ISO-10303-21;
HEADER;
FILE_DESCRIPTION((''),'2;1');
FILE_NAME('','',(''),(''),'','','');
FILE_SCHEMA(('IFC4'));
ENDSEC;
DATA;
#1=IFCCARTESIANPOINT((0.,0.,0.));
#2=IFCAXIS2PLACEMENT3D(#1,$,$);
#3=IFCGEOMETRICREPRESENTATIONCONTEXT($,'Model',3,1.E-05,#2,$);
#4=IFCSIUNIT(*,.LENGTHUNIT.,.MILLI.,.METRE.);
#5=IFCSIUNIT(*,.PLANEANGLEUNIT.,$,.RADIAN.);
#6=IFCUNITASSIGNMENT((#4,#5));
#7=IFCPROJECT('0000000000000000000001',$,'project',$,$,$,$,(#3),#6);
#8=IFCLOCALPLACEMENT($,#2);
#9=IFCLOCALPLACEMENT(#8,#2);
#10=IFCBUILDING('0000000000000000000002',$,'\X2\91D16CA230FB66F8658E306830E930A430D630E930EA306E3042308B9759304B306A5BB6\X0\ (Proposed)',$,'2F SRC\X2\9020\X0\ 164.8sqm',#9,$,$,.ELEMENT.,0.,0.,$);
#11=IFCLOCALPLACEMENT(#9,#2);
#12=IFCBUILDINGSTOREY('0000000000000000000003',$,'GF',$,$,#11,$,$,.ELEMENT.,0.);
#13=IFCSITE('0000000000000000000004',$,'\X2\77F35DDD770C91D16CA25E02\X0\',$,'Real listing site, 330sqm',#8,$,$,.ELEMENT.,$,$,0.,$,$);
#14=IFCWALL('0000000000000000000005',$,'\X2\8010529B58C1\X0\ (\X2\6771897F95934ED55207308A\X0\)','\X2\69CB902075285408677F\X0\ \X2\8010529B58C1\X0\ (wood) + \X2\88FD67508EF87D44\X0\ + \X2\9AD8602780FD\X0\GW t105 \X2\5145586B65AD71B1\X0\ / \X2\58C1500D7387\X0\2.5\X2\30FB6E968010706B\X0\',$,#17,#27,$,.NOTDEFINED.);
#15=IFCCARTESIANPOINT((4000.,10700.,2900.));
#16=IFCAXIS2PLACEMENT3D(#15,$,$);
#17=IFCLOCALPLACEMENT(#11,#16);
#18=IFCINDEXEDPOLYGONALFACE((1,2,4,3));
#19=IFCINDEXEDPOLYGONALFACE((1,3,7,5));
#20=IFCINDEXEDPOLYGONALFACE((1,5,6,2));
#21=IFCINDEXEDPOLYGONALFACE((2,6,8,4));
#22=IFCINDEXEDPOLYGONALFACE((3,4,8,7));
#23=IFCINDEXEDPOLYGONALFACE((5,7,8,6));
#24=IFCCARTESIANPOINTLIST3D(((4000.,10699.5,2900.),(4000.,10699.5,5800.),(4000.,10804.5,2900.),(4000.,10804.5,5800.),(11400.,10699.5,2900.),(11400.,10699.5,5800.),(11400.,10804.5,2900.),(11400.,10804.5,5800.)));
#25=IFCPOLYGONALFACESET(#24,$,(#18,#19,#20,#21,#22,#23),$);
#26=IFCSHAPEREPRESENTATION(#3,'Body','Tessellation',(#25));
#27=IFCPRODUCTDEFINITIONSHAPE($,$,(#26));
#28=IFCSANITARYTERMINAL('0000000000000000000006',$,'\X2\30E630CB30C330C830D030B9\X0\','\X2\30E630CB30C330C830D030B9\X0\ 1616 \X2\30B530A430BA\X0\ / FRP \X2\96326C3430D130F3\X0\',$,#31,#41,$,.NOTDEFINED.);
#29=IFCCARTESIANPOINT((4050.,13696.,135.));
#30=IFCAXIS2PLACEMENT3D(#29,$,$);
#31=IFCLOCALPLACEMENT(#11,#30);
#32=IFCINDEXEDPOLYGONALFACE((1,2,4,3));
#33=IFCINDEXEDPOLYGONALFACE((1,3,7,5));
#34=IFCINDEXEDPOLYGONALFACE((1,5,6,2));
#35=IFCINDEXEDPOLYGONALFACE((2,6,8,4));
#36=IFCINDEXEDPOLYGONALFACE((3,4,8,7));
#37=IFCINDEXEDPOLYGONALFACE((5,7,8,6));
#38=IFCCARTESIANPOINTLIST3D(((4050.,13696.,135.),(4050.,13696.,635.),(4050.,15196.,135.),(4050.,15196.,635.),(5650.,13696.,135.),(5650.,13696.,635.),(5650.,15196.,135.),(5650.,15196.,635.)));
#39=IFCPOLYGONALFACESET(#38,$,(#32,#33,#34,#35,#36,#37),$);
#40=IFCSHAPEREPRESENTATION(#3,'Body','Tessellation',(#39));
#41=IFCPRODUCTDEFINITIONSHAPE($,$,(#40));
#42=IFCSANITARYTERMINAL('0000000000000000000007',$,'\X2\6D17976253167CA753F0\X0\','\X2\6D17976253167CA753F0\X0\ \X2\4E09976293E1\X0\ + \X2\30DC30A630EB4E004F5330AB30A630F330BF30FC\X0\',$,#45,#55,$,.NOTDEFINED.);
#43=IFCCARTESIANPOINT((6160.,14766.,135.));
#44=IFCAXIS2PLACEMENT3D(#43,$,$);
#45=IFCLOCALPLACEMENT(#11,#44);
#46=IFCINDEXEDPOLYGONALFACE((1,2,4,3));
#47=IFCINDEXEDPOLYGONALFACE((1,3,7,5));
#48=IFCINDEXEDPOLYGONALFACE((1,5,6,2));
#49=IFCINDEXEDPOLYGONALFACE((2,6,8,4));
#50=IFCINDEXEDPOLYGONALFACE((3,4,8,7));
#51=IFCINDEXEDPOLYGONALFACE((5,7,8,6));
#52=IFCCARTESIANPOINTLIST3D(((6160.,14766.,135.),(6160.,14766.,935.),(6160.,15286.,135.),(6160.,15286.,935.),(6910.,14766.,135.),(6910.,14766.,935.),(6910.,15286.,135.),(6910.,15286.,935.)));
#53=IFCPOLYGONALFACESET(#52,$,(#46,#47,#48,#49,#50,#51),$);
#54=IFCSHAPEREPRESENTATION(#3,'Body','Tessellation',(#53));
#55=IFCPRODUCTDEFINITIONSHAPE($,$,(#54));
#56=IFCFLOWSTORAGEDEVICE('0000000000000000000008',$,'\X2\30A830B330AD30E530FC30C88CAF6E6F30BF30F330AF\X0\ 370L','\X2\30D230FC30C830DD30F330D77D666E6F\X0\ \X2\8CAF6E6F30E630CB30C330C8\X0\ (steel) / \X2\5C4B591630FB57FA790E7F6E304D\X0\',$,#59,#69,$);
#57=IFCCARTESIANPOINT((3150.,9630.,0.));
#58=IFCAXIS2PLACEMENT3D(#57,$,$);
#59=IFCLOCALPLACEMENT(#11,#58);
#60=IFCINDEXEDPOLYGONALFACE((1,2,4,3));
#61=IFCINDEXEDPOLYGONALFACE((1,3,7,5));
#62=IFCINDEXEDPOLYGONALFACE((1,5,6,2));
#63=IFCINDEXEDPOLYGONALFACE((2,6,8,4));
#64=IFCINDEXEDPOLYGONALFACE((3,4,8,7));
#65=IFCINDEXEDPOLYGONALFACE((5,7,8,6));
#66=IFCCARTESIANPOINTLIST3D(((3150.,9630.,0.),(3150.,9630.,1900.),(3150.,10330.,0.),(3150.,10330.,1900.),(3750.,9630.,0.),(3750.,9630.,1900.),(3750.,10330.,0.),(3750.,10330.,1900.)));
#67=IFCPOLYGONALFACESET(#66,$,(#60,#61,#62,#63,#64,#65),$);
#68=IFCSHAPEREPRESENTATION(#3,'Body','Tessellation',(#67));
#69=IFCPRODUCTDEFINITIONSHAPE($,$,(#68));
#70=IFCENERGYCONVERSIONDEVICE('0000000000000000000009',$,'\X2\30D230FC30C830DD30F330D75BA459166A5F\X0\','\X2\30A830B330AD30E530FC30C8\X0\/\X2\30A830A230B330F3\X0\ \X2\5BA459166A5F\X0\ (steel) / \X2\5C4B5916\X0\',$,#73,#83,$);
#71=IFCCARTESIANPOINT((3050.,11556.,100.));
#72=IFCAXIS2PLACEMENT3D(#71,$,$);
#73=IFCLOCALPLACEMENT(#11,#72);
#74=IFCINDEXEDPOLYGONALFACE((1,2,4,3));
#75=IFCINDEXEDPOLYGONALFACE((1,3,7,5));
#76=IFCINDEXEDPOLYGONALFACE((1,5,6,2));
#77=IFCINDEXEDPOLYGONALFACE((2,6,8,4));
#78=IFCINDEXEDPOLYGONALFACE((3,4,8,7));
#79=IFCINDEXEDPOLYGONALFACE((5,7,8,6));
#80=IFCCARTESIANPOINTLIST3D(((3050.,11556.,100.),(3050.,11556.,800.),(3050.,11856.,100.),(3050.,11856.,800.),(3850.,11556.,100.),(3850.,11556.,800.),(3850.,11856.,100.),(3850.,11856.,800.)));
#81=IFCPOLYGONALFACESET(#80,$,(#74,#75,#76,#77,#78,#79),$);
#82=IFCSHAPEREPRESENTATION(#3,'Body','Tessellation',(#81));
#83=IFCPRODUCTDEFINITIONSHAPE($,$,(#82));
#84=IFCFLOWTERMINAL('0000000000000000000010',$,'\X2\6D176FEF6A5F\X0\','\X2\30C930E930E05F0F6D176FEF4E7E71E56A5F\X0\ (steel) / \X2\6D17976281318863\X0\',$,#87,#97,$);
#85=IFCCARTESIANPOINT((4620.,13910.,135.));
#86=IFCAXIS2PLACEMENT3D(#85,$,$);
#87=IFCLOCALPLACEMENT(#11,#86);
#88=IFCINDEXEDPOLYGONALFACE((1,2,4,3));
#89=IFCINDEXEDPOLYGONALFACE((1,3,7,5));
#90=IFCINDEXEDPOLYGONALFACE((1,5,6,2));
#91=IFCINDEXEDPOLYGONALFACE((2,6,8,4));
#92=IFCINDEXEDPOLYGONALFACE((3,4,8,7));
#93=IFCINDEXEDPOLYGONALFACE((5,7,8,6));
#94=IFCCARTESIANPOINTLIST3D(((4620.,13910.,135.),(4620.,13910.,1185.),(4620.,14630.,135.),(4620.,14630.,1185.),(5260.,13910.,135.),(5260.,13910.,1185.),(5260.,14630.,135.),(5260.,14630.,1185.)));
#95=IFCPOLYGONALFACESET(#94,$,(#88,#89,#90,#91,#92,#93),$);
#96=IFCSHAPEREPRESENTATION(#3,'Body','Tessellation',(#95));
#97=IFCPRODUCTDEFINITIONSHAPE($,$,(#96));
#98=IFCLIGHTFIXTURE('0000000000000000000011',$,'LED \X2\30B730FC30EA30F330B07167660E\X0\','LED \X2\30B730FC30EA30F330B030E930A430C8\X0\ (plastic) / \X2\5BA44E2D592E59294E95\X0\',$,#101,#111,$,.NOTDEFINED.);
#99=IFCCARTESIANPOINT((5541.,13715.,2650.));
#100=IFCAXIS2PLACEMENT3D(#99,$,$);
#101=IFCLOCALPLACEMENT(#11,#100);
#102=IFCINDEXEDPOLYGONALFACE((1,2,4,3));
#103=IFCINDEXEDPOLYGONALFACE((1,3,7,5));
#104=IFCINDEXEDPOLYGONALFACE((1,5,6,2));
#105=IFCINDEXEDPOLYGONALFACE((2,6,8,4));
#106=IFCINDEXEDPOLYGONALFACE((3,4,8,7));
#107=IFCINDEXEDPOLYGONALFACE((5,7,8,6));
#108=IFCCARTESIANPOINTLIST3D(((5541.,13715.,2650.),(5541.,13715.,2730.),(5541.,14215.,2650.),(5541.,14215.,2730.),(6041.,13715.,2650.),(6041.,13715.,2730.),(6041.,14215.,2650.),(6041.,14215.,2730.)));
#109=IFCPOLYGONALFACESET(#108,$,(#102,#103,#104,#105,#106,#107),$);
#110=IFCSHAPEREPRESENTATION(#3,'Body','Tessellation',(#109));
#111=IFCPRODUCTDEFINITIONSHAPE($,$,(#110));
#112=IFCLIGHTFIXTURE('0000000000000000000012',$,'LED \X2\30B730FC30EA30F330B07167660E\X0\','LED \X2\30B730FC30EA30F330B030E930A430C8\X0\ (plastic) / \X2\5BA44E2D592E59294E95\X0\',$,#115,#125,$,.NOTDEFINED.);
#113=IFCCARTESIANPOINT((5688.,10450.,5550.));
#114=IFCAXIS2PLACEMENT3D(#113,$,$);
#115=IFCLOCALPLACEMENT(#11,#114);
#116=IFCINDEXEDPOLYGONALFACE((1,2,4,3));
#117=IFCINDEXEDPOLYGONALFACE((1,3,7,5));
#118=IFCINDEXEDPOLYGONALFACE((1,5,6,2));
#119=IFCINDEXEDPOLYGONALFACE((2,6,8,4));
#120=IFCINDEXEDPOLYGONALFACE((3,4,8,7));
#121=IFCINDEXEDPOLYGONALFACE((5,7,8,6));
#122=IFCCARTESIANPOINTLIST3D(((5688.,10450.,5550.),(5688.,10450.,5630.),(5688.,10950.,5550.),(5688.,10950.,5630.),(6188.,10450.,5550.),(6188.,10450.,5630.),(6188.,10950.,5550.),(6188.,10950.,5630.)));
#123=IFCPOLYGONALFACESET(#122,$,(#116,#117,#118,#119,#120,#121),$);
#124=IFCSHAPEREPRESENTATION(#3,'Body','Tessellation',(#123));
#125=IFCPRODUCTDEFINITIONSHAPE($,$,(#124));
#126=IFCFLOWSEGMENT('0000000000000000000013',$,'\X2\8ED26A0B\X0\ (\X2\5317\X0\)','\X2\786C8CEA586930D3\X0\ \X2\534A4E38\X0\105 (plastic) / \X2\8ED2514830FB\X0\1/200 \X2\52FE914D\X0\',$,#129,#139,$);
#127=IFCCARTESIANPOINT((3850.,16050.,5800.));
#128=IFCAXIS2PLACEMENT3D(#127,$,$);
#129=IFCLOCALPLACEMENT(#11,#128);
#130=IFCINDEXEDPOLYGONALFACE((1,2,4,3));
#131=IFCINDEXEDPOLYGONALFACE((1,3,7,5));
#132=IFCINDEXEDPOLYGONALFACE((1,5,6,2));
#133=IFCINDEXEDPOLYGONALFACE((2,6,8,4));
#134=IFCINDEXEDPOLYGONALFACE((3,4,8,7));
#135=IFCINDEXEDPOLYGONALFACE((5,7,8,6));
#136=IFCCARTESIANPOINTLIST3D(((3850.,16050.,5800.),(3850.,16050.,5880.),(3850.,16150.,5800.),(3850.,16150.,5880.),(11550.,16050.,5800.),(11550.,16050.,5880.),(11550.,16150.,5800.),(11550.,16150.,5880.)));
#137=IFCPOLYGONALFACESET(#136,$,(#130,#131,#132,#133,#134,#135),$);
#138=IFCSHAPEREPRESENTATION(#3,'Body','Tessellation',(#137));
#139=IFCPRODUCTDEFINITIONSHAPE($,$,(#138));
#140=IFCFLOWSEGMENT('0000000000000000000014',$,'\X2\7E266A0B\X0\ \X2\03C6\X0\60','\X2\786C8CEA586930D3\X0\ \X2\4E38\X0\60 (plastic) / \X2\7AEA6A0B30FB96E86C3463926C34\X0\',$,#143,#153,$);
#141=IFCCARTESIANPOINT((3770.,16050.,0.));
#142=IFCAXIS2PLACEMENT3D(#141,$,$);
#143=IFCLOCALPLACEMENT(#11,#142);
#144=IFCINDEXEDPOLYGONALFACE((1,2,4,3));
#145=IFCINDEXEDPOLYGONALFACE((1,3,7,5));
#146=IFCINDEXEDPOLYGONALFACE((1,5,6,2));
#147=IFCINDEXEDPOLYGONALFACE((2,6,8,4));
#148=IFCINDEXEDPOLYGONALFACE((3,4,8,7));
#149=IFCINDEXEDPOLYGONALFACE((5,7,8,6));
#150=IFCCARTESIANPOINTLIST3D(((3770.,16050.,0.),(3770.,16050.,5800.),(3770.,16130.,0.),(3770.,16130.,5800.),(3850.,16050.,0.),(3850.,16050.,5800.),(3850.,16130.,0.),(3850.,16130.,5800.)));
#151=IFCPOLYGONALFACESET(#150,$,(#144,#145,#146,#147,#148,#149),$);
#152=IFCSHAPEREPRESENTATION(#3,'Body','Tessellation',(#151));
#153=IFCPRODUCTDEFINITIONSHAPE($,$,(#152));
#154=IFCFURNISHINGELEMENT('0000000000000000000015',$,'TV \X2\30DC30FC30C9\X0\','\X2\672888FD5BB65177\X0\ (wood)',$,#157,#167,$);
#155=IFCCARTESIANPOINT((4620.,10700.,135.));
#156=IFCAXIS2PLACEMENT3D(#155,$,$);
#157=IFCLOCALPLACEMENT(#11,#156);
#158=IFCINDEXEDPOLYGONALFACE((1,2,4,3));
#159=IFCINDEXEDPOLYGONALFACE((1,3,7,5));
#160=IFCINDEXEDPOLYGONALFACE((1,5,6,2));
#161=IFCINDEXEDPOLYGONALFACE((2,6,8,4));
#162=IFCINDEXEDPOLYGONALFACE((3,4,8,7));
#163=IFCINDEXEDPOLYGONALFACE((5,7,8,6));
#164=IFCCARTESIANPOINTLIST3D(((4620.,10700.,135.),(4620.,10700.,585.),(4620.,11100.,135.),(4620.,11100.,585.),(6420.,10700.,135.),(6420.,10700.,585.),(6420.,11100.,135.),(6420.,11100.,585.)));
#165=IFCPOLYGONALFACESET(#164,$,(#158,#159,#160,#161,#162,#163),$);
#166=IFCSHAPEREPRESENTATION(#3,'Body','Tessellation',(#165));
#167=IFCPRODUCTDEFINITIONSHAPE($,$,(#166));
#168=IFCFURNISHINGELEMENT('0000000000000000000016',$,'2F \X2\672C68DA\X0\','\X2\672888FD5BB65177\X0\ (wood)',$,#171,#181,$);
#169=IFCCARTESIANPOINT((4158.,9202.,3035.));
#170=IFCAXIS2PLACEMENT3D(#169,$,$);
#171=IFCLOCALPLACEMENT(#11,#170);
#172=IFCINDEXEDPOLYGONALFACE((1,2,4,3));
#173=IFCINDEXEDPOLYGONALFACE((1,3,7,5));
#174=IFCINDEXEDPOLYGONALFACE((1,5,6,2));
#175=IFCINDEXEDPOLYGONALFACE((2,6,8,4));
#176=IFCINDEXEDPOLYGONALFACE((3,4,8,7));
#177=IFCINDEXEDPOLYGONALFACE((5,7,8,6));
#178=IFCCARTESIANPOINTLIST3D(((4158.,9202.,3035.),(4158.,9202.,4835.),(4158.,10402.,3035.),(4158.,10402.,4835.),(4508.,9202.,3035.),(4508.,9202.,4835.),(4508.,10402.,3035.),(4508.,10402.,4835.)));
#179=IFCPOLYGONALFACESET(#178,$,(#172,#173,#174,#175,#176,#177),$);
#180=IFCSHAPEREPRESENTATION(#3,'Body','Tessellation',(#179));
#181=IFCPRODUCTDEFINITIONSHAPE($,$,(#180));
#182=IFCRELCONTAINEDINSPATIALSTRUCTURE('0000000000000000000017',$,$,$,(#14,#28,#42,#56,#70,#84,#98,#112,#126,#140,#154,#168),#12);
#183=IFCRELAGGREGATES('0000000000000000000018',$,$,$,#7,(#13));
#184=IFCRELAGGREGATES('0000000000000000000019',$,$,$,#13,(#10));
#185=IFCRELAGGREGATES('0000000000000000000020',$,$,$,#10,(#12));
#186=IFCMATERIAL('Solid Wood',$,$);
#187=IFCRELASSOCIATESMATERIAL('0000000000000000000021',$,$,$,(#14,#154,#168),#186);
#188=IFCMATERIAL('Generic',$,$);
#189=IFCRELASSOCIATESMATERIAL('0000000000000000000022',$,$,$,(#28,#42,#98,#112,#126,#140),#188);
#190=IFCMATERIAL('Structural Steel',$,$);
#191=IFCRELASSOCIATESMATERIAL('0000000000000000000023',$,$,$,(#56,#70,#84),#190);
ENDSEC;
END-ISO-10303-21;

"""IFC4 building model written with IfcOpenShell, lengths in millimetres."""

from ifc_helpers import new_model, si_unit, frame, frame_2d, origin, place, context, project, spatial, rectangle, extrude, material, element, save


model = new_model("IFC4")

# Units and contexts
model_context = context("Model", 3, precision=1e-05, world=origin())
ifc_project = project(units=[si_unit("LENGTHUNIT", "METRE", prefix="MILLI"), si_unit("PLANEANGLEUNIT", "RADIAN")], contexts=[model_context])

# Site, building, storey
site_placement = place(None, origin())
site = spatial("IfcSite", under=ifc_project, at=site_placement, Name="石川県金沢市", ObjectType="Real listing site, 330sqm", CompositionType="ELEMENT", RefElevation=0.0)
building_placement = place(site_placement, origin())
building = spatial("IfcBuilding", under=site, at=building_placement, Name="金沢・書斎とライブラリのある静かな家 (Proposed)", ObjectType="2F SRC造 164.8sqm", CompositionType="ELEMENT", ElevationOfRefHeight=0.0, ElevationOfTerrain=0.0)
storey_placement = place(building_placement, origin())
storey = spatial("IfcBuildingStorey", under=building, at=storey_placement, Name="GF", CompositionType="ELEMENT", Elevation=0.0)

# Shared definitions
ifc_material_1 = material(Name="Solid Wood")

# Wall
wall_1_placement = place(storey_placement, frame((4000.0, 10700.0, 2900.0)))
element("IfcWall", 1, at=wall_1_placement, inside=storey, material=ifc_material_1, Name="耐力壁 (東西間仕切り)", Description="構造用合板 耐力壁 (wood) + 製材軸組 + 高性能GW t105 充填断熱 / 壁倍率2.5・準耐火", PredefinedType="NOTDEFINED", context=model_context, shape_type="SweptSolid", body=[
    extrude(rectangle(XDim=7400.0, YDim=105.0, at=frame_2d((3700.0, 52.0))), frame((4000.0, 10700.0, 2900.0)), (0.0, 0.0, 1.0), 2900.0),
])

# Sanitary terminals
ifc_material_2 = material(Name="Generic")
sanitary_terminal_1_placement = place(storey_placement, frame((4050.0, 13696.0, 135.0)))
element("IfcSanitaryTerminal", 2, at=sanitary_terminal_1_placement, inside=storey, material=ifc_material_2, Name="ユニットバス", Description="ユニットバス 1616 サイズ / FRP 防水パン", PredefinedType="NOTDEFINED", context=model_context, shape_type="SweptSolid", body=[
    extrude(rectangle(XDim=1600.0, YDim=1500.0, at=frame_2d((800.0, 750.0))), frame((4050.0, 13696.0, 135.0)), (0.0, 0.0, 1.0), 500.0),
])
sanitary_terminal_2_placement = place(storey_placement, frame((6160.0, 14766.0, 135.0)))
element("IfcSanitaryTerminal", 3, at=sanitary_terminal_2_placement, inside=storey, material=ifc_material_2, Name="洗面化粧台", Description="洗面化粧台 三面鏡 + ボウル一体カウンター", PredefinedType="NOTDEFINED", context=model_context, shape_type="SweptSolid", body=[
    extrude(rectangle(XDim=750.0, YDim=520.0, at=frame_2d((375.0, 260.0))), frame((6160.0, 14766.0, 135.0)), (0.0, 0.0, 1.0), 800.0),
])

# Flow storage device
ifc_material_3 = material(Name="Structural Steel")
flow_storage_device_placement = place(storey_placement, frame((3150.0, 9630.0, 0.0)))
element("IfcFlowStorageDevice", 4, at=flow_storage_device_placement, inside=storey, material=ifc_material_3, Name="エコキュート貯湯タンク 370L", Description="ヒートポンプ給湯 貯湯ユニット (steel) / 屋外・基礎置き", context=model_context, shape_type="SweptSolid", body=[
    extrude(rectangle(XDim=600.0, YDim=700.0, at=frame_2d((300.0, 350.0))), frame((3150.0, 9630.0, 0.0)), (0.0, 0.0, 1.0), 1900.0),
])

# Energy conversion device
energy_conversion_device_placement = place(storey_placement, frame((3050.0, 11556.0, 100.0)))
element("IfcEnergyConversionDevice", 5, at=energy_conversion_device_placement, inside=storey, material=ifc_material_3, Name="ヒートポンプ室外機", Description="エコキュート/エアコン 室外機 (steel) / 屋外", context=model_context, shape_type="SweptSolid", body=[
    extrude(rectangle(XDim=800.0, YDim=300.0, at=frame_2d((400.0, 150.0))), frame((3050.0, 11556.0, 100.0)), (0.0, 0.0, 1.0), 700.0),
])

# Flow terminal
flow_terminal_placement = place(storey_placement, frame((4620.0, 13910.0, 135.0)))
element("IfcFlowTerminal", 6, at=flow_terminal_placement, inside=storey, material=ifc_material_3, Name="洗濯機", Description="ドラム式洗濯乾燥機 (steel) / 洗面脱衣", context=model_context, shape_type="SweptSolid", body=[
    extrude(rectangle(XDim=640.0, YDim=720.0, at=frame_2d((320.0, 360.0))), frame((4620.0, 13910.0, 135.0)), (0.0, 0.0, 1.0), 1050.0),
])

# Light fixtures
light_fixture_1_placement = place(storey_placement, frame((5541.0, 13715.0, 2650.0)))
element("IfcLightFixture", 7, at=light_fixture_1_placement, inside=storey, material=ifc_material_2, Name="LED シーリング照明", Description="LED シーリングライト (plastic) / 室中央天井", PredefinedType="NOTDEFINED", context=model_context, shape_type="SweptSolid", body=[
    extrude(rectangle(XDim=500.0, YDim=500.0, at=frame_2d((250.0, 250.0))), frame((5541.0, 13715.0, 2650.0)), (0.0, 0.0, 1.0), 80.0),
])
light_fixture_2_placement = place(storey_placement, frame((5688.0, 10450.0, 5550.0)))
element("IfcLightFixture", 8, at=light_fixture_2_placement, inside=storey, material=ifc_material_2, Name="LED シーリング照明", Description="LED シーリングライト (plastic) / 室中央天井", PredefinedType="NOTDEFINED", context=model_context, shape_type="SweptSolid", body=[
    extrude(rectangle(XDim=500.0, YDim=500.0, at=frame_2d((250.0, 250.0))), frame((5688.0, 10450.0, 5550.0)), (0.0, 0.0, 1.0), 80.0),
])

# Flow segments
flow_segment_1_placement = place(storey_placement, frame((3850.0, 16050.0, 5800.0)))
element("IfcFlowSegment", 9, at=flow_segment_1_placement, inside=storey, material=ifc_material_2, Name="軒樋 (北)", Description="硬質塩ビ 半丸105 (plastic) / 軒先・1/200 勾配", context=model_context, shape_type="SweptSolid", body=[
    extrude(rectangle(XDim=7700.0, YDim=100.0, at=frame_2d((3850.0, 50.0))), frame((3850.0, 16050.0, 5800.0)), (0.0, 0.0, 1.0), 80.0),
])
flow_segment_2_placement = place(storey_placement, frame((3770.0, 16050.0, 0.0)))
element("IfcFlowSegment", 10, at=flow_segment_2_placement, inside=storey, material=ifc_material_2, Name="縦樋 φ60", Description="硬質塩ビ 丸60 (plastic) / 竪樋・雨水排水", context=model_context, shape_type="SweptSolid", body=[
    extrude(rectangle(XDim=80.0, YDim=80.0, at=frame_2d((40.0, 40.0))), frame((3770.0, 16050.0, 0.0)), (0.0, 0.0, 1.0), 5800.0),
])

# Furnishing elements
furnishing_1_placement = place(storey_placement, frame((4620.0, 10700.0, 135.0)))
element("IfcFurnishingElement", 11, at=furnishing_1_placement, inside=storey, material=ifc_material_1, Name="TV ボード", Description="木製家具 (wood)", context=model_context, shape_type="SweptSolid", body=[
    extrude(rectangle(XDim=1800.0, YDim=400.0, at=frame_2d((900.0, 200.0))), frame((4620.0, 10700.0, 135.0)), (0.0, 0.0, 1.0), 450.0),
])
furnishing_2_placement = place(storey_placement, frame((4158.0, 9202.0, 3035.0)))
element("IfcFurnishingElement", 12, at=furnishing_2_placement, inside=storey, material=ifc_material_1, Name="2F 本棚", Description="木製家具 (wood)", context=model_context, shape_type="SweptSolid", body=[
    extrude(rectangle(XDim=350.0, YDim=1200.0, at=frame_2d((175.0, 600.0))), frame((4158.0, 9202.0, 3035.0)), (0.0, 0.0, 1.0), 1800.0),
])

save(model, "model.ifc")
